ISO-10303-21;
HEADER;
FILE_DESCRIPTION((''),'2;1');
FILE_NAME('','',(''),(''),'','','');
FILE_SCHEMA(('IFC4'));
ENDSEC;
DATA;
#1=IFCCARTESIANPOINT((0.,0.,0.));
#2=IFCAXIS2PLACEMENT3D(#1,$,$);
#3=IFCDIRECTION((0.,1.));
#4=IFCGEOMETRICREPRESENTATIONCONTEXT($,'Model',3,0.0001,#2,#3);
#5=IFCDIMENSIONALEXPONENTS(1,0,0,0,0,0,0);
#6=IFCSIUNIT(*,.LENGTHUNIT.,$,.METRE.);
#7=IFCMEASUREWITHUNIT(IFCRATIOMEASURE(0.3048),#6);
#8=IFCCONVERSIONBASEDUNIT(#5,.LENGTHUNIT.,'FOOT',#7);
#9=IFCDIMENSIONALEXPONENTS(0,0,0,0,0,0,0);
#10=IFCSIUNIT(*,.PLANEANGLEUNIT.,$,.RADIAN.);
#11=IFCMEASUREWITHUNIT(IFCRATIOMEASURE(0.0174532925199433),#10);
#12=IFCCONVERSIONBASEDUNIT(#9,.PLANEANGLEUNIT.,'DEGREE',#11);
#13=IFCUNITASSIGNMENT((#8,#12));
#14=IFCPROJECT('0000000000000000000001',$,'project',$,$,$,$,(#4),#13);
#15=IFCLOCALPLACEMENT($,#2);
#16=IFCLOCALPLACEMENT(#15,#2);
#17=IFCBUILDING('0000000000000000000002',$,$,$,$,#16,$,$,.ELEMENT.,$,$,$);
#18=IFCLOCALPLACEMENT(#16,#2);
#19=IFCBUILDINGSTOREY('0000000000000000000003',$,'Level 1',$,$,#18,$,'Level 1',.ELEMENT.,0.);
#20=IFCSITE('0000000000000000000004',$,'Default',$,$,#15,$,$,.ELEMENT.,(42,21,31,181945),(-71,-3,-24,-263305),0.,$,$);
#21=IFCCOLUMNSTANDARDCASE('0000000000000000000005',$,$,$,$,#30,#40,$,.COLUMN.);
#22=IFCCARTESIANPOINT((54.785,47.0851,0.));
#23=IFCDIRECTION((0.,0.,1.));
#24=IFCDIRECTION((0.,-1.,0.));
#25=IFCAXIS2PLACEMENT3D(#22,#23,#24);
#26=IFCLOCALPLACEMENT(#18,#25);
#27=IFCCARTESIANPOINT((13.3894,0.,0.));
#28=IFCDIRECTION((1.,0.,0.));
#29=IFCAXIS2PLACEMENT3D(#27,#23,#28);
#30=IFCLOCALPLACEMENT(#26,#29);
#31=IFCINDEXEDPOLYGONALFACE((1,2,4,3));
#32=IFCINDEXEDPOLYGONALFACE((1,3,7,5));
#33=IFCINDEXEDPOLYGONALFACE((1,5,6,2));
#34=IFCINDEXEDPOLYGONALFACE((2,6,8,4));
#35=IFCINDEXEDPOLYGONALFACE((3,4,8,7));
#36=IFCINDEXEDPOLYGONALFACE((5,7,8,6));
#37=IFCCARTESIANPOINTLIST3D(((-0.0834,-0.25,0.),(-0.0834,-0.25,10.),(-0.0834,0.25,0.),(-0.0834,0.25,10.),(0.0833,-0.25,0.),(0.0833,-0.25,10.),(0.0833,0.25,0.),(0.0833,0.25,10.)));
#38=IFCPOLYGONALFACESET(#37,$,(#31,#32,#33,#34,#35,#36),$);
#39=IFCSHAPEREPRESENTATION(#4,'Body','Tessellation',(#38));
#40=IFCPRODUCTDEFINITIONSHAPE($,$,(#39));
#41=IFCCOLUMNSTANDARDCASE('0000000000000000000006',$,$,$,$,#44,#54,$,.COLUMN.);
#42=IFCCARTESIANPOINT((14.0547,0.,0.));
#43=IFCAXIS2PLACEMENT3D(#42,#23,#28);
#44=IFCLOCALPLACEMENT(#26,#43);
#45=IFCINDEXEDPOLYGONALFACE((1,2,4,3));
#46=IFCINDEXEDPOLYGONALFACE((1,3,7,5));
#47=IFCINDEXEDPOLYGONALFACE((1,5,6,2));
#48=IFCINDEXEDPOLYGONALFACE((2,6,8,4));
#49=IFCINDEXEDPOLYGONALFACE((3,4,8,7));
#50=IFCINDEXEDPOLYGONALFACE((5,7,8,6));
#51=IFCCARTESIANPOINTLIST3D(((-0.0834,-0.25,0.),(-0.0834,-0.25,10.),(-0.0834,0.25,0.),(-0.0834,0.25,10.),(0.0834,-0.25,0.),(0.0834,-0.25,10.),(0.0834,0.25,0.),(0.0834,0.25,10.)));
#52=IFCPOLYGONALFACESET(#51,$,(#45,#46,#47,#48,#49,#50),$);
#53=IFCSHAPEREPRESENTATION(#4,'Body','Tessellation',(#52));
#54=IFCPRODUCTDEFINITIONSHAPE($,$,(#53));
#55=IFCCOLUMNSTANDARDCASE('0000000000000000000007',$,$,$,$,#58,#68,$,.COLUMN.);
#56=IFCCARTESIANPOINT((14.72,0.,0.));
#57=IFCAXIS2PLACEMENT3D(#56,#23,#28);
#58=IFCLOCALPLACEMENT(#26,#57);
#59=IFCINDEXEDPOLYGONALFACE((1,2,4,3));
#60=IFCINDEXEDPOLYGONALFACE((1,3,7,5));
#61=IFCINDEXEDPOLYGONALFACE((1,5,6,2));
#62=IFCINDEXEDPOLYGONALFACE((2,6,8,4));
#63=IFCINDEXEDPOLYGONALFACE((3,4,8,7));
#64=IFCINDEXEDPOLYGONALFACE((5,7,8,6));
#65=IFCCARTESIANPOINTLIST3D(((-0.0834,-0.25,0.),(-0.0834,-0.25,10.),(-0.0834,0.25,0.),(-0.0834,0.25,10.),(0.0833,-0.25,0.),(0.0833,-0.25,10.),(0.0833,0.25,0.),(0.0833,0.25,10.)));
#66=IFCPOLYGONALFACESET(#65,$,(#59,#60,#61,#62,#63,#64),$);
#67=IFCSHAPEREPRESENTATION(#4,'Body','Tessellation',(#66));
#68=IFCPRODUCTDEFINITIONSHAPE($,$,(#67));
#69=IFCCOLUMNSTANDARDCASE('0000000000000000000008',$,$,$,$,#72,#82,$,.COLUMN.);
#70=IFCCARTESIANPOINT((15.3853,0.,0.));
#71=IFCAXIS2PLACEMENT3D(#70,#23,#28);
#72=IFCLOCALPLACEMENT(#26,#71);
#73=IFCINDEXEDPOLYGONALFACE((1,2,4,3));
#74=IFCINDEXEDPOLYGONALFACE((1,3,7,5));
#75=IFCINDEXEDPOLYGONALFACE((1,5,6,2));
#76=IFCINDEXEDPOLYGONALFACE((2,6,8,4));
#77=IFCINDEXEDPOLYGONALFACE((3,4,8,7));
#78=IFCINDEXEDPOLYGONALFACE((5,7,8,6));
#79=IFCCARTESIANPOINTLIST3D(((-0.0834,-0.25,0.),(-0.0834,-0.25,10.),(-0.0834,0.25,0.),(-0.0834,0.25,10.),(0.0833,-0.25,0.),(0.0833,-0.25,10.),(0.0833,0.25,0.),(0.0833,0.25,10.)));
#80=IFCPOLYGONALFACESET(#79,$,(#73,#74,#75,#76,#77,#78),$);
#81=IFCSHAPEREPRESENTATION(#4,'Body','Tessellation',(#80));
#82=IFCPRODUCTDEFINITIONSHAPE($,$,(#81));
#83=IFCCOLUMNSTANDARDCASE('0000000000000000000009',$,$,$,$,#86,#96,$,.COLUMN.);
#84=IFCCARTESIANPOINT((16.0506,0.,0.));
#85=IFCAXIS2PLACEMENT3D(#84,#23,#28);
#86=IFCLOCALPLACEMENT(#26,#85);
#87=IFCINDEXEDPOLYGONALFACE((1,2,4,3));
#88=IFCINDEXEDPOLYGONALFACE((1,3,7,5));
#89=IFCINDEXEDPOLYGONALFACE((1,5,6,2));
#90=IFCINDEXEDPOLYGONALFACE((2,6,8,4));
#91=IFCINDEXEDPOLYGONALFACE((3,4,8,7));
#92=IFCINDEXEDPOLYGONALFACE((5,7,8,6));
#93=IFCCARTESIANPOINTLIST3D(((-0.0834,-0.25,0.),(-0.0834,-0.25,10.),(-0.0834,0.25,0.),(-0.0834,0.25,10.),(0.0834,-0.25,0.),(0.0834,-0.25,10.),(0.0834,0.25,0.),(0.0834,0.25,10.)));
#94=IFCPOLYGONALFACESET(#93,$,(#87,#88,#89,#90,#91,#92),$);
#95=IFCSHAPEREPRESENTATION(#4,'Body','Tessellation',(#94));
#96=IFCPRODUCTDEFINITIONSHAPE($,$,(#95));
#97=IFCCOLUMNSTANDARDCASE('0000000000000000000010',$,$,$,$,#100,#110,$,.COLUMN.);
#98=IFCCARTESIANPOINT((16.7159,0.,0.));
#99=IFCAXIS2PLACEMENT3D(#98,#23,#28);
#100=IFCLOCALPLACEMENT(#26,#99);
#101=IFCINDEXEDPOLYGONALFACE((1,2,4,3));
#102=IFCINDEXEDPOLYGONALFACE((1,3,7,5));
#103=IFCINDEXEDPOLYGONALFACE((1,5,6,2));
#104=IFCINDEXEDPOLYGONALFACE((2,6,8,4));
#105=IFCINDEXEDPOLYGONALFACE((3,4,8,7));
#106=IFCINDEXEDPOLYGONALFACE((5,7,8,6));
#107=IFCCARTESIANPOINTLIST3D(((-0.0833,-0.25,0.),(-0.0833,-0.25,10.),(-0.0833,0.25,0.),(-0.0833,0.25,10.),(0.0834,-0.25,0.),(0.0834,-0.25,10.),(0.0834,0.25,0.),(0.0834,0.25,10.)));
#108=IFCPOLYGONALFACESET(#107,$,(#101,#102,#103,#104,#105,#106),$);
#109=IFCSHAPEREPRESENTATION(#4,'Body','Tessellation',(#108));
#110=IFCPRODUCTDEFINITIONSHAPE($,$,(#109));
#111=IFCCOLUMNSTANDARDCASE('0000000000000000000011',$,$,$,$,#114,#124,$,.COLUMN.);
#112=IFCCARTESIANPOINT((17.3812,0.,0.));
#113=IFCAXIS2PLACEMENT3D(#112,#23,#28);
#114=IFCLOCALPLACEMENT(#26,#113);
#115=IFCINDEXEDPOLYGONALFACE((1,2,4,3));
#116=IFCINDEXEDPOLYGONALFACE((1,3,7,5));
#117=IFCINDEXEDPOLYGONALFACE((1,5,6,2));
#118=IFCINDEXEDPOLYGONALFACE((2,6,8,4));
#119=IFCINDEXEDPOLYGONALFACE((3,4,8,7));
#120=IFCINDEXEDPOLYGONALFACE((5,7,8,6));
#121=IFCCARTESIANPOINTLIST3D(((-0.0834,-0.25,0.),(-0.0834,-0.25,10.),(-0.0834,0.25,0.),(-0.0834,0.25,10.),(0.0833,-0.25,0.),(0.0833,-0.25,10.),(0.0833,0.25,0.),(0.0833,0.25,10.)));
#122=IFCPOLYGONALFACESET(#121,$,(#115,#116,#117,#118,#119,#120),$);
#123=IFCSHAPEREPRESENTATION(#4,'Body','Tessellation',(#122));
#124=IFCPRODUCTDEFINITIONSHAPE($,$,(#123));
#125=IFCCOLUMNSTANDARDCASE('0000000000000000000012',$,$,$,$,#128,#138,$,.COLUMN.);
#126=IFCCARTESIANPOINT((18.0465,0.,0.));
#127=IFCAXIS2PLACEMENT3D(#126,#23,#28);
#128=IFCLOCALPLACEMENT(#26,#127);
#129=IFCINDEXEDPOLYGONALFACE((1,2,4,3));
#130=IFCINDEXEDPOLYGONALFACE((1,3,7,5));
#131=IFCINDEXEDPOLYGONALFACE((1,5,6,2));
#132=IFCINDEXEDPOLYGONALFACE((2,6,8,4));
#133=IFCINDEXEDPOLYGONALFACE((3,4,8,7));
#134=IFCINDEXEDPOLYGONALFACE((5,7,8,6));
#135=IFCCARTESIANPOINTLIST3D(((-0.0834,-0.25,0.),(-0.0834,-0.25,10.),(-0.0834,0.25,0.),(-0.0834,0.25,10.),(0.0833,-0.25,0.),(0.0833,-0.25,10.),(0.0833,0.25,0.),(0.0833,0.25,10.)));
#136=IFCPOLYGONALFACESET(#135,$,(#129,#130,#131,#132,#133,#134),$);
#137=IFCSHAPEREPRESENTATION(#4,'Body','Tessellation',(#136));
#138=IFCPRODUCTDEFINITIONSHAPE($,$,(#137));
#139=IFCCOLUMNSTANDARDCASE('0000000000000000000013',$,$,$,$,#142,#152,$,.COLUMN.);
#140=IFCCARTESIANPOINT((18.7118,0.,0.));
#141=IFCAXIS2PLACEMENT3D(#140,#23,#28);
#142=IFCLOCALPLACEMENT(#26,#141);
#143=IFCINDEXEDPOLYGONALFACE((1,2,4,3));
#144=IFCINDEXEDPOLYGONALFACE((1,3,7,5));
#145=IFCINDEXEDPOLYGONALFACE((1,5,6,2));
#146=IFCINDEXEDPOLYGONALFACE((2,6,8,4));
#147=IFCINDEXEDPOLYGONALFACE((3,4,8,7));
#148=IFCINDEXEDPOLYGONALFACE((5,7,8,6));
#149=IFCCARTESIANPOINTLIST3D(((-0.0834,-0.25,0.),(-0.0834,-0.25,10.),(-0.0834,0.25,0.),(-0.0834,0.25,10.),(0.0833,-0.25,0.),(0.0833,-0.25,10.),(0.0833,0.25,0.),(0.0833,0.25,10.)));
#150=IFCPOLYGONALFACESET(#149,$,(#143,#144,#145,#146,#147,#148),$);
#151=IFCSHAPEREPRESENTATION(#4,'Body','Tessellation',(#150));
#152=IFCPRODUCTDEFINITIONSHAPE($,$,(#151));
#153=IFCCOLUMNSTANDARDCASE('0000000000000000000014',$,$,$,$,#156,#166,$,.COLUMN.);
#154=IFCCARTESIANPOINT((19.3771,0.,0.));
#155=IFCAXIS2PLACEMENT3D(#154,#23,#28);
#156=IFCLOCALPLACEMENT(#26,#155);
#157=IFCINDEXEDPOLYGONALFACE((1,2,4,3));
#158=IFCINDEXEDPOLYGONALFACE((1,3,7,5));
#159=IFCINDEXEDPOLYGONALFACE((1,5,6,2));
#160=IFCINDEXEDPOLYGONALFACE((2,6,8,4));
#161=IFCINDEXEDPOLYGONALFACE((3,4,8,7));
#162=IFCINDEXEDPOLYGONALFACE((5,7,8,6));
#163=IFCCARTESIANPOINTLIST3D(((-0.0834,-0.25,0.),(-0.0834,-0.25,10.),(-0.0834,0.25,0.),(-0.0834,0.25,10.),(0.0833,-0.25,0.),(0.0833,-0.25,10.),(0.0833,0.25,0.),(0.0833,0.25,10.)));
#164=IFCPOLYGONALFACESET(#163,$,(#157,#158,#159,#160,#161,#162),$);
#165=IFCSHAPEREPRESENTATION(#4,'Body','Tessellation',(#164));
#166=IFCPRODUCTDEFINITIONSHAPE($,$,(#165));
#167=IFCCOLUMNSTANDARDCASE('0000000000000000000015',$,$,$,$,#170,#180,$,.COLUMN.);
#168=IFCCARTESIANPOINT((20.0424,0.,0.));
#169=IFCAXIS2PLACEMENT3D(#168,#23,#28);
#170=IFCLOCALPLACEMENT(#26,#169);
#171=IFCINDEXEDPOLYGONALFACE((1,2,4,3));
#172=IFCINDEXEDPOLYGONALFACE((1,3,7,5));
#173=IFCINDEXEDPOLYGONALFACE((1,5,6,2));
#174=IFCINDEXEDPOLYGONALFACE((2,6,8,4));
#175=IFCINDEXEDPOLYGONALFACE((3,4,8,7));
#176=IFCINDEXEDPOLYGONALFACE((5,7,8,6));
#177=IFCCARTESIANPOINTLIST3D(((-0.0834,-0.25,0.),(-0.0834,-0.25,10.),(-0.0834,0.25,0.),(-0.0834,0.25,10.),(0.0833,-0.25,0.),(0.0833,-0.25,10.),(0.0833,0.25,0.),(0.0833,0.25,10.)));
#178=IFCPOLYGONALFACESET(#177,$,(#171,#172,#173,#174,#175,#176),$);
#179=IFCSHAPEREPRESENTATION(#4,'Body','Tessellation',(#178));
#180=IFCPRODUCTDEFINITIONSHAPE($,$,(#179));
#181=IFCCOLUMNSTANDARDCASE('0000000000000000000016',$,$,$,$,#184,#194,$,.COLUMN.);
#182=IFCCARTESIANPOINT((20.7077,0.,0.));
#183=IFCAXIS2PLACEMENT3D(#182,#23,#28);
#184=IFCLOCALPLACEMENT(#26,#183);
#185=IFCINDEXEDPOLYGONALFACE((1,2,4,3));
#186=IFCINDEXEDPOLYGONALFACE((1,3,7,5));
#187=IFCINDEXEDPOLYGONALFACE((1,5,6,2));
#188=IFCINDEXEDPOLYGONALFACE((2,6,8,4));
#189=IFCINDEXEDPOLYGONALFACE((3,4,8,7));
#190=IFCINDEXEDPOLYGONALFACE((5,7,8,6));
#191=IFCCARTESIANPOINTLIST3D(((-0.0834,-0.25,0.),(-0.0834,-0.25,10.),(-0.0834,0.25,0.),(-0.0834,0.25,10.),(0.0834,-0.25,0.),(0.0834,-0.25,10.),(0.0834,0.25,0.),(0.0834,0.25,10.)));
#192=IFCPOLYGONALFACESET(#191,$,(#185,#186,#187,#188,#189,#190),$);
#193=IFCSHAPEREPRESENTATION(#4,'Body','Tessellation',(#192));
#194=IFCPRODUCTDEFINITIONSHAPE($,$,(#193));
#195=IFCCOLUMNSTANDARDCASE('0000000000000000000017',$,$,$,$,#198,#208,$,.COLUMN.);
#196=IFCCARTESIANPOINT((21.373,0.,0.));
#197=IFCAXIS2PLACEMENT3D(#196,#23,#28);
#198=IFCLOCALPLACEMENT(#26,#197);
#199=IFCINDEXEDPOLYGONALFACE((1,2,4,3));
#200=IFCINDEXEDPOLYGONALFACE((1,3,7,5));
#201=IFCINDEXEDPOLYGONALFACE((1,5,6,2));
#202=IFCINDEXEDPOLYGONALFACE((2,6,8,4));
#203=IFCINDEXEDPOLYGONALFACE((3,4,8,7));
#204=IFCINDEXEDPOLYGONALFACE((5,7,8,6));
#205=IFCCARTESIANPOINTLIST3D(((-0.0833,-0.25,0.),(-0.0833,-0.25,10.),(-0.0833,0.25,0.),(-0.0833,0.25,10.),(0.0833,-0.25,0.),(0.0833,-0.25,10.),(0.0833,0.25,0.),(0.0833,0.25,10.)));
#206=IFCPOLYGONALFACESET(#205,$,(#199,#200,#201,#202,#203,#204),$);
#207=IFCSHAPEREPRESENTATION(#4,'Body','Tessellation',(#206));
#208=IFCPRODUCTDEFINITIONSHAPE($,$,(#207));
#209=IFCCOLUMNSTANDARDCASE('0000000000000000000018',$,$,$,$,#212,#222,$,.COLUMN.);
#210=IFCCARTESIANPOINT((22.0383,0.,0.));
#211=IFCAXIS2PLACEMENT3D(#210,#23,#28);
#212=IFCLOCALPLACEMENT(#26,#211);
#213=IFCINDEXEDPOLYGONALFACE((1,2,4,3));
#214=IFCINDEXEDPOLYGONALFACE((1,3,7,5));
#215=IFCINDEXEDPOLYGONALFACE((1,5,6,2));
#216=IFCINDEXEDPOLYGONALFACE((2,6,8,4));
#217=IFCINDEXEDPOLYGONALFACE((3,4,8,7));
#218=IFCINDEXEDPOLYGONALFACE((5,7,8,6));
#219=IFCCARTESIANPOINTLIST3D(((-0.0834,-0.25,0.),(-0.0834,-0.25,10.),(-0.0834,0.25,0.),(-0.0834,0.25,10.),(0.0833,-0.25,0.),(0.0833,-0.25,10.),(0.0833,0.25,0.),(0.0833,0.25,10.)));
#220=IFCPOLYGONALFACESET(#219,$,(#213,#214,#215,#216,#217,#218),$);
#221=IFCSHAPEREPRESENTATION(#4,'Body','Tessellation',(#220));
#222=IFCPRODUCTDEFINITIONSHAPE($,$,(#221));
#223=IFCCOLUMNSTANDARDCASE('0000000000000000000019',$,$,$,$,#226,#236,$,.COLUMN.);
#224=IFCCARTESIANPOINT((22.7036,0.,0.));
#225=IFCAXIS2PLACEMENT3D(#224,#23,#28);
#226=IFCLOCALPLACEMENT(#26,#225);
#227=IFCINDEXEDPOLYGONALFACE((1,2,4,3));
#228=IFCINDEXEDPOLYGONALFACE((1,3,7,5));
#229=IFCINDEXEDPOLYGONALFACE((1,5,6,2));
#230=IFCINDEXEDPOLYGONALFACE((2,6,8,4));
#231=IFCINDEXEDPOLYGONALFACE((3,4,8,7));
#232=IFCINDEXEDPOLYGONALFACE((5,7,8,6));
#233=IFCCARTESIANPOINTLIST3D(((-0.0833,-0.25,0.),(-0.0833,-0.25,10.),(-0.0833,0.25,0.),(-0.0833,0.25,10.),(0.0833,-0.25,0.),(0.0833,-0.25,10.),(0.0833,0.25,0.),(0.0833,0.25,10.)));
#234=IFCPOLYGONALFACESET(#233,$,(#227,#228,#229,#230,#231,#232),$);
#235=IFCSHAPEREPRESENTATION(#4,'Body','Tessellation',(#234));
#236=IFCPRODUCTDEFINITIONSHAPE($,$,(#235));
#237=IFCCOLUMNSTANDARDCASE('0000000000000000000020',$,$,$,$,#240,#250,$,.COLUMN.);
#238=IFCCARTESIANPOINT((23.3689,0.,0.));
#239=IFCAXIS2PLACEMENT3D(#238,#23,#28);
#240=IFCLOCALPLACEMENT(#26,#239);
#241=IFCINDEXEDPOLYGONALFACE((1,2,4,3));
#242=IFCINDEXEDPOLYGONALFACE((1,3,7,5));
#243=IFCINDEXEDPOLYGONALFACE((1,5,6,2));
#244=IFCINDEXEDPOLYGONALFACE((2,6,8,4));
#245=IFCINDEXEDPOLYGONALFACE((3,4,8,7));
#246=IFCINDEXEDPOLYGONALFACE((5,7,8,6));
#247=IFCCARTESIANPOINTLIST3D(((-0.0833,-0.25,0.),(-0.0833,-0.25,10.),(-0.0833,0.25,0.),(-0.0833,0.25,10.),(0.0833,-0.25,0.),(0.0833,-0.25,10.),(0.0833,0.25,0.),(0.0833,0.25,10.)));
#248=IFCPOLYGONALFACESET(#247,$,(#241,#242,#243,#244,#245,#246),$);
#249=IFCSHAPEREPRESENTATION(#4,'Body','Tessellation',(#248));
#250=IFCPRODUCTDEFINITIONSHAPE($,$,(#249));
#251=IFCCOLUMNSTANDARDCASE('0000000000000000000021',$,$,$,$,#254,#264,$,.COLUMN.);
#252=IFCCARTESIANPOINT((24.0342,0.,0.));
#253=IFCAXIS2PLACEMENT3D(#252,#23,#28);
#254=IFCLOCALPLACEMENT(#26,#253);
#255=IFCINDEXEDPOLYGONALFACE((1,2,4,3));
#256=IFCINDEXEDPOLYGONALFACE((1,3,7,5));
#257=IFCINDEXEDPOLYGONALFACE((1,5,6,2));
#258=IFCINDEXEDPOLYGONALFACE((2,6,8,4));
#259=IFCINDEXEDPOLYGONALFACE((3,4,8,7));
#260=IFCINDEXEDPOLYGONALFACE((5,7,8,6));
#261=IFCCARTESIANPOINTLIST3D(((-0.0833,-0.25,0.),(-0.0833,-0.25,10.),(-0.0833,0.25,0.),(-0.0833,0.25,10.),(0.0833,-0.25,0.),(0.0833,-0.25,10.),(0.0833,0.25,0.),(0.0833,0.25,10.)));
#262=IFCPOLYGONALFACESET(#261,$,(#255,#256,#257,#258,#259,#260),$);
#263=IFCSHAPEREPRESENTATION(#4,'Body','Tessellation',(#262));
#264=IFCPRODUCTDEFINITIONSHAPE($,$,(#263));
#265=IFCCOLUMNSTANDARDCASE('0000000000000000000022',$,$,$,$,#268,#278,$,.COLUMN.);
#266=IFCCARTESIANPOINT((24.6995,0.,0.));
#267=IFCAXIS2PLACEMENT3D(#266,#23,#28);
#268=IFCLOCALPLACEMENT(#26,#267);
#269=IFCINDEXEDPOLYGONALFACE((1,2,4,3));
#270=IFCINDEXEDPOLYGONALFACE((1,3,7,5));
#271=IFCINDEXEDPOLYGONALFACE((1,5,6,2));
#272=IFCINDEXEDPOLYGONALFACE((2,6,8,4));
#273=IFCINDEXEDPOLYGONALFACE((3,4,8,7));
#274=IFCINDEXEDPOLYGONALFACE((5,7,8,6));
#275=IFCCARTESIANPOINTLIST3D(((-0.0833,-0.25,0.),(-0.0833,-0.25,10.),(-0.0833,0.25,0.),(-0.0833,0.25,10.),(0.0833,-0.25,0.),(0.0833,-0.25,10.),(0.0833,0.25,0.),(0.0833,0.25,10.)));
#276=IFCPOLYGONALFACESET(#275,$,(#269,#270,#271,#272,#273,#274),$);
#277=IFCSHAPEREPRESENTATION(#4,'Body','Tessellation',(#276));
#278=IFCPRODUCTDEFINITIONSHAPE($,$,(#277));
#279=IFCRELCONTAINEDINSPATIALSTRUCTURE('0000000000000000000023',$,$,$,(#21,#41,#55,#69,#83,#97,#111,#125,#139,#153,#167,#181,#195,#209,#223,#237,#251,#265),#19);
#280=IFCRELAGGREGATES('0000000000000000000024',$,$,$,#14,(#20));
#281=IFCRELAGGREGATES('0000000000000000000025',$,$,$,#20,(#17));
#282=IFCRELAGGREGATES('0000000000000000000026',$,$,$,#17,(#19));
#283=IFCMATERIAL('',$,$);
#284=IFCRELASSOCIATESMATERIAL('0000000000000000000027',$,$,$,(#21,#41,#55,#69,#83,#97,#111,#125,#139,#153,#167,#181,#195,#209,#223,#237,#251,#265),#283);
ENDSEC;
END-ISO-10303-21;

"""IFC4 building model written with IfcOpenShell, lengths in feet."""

from ifc_helpers import new_model, entity, si_unit, converted_unit, direction, frame, origin, place, context, project, spatial, rectangle, extrude, material, element, save


model = new_model("IFC4")

# Units and contexts
model_context = context("Model", 3, precision=0.0001, world=origin(), true_north=direction((0.0, 1.0)))
ifc_project = project(units=[converted_unit("LENGTHUNIT", "FOOT", entity("IfcRatioMeasure", 0.3048), si_unit("LENGTHUNIT", "METRE"), dimensions=[1, 0, 0, 0, 0, 0, 0]), converted_unit("PLANEANGLEUNIT", "DEGREE", entity("IfcRatioMeasure", 0.0174532925199433), si_unit("PLANEANGLEUNIT", "RADIAN"), dimensions=[0, 0, 0, 0, 0, 0, 0])], contexts=[model_context])

# Site, building, storey
site_placement = place(None, origin())
site = spatial("IfcSite", under=ifc_project, at=site_placement, Name="Default", CompositionType="ELEMENT", RefLatitude=(42, 21, 31, 181945), RefLongitude=(-71, -3, -24, -263305), RefElevation=0.0)
building_placement = place(site_placement, origin())
building = spatial("IfcBuilding", under=site, at=building_placement, CompositionType="ELEMENT")
storey_placement = place(building_placement, origin())
storey = spatial("IfcBuildingStorey", under=building, at=storey_placement, Name="Level 1", LongName="Level 1", CompositionType="ELEMENT", Elevation=0.0)

# Columns
ifc_material = material(Name="")
placement = place(storey_placement, frame((54.785, 47.0851, 0.0), z_axis=(0.0, 0.0, 1.0), x_axis=(0.0, -1.0, 0.0)))
for number, where, z_axis, x_axis in (
    (1, (13.3894, 0.0, 0.0), (0.0, 0.0, 1.0), (1.0, 0.0, 0.0)),
    (2, (14.0547, 0.0, 0.0), (0.0, 0.0, 1.0), (1.0, 0.0, 0.0)),
    (3, (14.72, 0.0, 0.0), (0.0, 0.0, 1.0), (1.0, 0.0, 0.0)),
    (4, (15.3853, 0.0, 0.0), (0.0, 0.0, 1.0), (1.0, 0.0, 0.0)),
    (5, (16.0506, 0.0, 0.0), (0.0, 0.0, 1.0), (1.0, 0.0, 0.0)),
    (6, (16.7159, 0.0, 0.0), (0.0, 0.0, 1.0), (1.0, 0.0, 0.0)),
    (7, (17.3812, 0.0, 0.0), (0.0, 0.0, 1.0), (1.0, 0.0, 0.0)),
    (8, (18.0465, 0.0, 0.0), (0.0, 0.0, 1.0), (1.0, 0.0, 0.0)),
    (9, (18.7118, 0.0, 0.0), (0.0, 0.0, 1.0), (1.0, 0.0, 0.0)),
    (10, (19.3771, 0.0, 0.0), (0.0, 0.0, 1.0), (1.0, 0.0, 0.0)),
    (11, (20.0424, 0.0, 0.0), (0.0, 0.0, 1.0), (1.0, 0.0, 0.0)),
    (12, (20.7077, 0.0, 0.0), (0.0, 0.0, 1.0), (1.0, 0.0, 0.0)),
    (13, (21.373, 0.0, 0.0), (0.0, 0.0, 1.0), (1.0, 0.0, 0.0)),
    (14, (22.0383, 0.0, 0.0), (0.0, 0.0, 1.0), (1.0, 0.0, 0.0)),
    (15, (22.7036, 0.0, 0.0), (0.0, 0.0, 1.0), (1.0, 0.0, 0.0)),
    (16, (23.3689, 0.0, 0.0), (0.0, 0.0, 1.0), (1.0, 0.0, 0.0)),
    (17, (24.0342, 0.0, 0.0), (0.0, 0.0, 1.0), (1.0, 0.0, 0.0)),
    (18, (24.6995, 0.0, 0.0), (0.0, 0.0, 1.0), (1.0, 0.0, 0.0)),
):
    element("IfcColumnStandardCase", number, at=place(placement, frame(where, z_axis=z_axis, x_axis=x_axis)), inside=storey, material=ifc_material, PredefinedType="COLUMN", context=model_context, shape_type="SweptSolid", body=[
        extrude(rectangle(XDim=0.1667, YDim=0.5), origin(), (0.0, 0.0, 1.0), 10.0),
    ])

save(model, "model.ifc")
